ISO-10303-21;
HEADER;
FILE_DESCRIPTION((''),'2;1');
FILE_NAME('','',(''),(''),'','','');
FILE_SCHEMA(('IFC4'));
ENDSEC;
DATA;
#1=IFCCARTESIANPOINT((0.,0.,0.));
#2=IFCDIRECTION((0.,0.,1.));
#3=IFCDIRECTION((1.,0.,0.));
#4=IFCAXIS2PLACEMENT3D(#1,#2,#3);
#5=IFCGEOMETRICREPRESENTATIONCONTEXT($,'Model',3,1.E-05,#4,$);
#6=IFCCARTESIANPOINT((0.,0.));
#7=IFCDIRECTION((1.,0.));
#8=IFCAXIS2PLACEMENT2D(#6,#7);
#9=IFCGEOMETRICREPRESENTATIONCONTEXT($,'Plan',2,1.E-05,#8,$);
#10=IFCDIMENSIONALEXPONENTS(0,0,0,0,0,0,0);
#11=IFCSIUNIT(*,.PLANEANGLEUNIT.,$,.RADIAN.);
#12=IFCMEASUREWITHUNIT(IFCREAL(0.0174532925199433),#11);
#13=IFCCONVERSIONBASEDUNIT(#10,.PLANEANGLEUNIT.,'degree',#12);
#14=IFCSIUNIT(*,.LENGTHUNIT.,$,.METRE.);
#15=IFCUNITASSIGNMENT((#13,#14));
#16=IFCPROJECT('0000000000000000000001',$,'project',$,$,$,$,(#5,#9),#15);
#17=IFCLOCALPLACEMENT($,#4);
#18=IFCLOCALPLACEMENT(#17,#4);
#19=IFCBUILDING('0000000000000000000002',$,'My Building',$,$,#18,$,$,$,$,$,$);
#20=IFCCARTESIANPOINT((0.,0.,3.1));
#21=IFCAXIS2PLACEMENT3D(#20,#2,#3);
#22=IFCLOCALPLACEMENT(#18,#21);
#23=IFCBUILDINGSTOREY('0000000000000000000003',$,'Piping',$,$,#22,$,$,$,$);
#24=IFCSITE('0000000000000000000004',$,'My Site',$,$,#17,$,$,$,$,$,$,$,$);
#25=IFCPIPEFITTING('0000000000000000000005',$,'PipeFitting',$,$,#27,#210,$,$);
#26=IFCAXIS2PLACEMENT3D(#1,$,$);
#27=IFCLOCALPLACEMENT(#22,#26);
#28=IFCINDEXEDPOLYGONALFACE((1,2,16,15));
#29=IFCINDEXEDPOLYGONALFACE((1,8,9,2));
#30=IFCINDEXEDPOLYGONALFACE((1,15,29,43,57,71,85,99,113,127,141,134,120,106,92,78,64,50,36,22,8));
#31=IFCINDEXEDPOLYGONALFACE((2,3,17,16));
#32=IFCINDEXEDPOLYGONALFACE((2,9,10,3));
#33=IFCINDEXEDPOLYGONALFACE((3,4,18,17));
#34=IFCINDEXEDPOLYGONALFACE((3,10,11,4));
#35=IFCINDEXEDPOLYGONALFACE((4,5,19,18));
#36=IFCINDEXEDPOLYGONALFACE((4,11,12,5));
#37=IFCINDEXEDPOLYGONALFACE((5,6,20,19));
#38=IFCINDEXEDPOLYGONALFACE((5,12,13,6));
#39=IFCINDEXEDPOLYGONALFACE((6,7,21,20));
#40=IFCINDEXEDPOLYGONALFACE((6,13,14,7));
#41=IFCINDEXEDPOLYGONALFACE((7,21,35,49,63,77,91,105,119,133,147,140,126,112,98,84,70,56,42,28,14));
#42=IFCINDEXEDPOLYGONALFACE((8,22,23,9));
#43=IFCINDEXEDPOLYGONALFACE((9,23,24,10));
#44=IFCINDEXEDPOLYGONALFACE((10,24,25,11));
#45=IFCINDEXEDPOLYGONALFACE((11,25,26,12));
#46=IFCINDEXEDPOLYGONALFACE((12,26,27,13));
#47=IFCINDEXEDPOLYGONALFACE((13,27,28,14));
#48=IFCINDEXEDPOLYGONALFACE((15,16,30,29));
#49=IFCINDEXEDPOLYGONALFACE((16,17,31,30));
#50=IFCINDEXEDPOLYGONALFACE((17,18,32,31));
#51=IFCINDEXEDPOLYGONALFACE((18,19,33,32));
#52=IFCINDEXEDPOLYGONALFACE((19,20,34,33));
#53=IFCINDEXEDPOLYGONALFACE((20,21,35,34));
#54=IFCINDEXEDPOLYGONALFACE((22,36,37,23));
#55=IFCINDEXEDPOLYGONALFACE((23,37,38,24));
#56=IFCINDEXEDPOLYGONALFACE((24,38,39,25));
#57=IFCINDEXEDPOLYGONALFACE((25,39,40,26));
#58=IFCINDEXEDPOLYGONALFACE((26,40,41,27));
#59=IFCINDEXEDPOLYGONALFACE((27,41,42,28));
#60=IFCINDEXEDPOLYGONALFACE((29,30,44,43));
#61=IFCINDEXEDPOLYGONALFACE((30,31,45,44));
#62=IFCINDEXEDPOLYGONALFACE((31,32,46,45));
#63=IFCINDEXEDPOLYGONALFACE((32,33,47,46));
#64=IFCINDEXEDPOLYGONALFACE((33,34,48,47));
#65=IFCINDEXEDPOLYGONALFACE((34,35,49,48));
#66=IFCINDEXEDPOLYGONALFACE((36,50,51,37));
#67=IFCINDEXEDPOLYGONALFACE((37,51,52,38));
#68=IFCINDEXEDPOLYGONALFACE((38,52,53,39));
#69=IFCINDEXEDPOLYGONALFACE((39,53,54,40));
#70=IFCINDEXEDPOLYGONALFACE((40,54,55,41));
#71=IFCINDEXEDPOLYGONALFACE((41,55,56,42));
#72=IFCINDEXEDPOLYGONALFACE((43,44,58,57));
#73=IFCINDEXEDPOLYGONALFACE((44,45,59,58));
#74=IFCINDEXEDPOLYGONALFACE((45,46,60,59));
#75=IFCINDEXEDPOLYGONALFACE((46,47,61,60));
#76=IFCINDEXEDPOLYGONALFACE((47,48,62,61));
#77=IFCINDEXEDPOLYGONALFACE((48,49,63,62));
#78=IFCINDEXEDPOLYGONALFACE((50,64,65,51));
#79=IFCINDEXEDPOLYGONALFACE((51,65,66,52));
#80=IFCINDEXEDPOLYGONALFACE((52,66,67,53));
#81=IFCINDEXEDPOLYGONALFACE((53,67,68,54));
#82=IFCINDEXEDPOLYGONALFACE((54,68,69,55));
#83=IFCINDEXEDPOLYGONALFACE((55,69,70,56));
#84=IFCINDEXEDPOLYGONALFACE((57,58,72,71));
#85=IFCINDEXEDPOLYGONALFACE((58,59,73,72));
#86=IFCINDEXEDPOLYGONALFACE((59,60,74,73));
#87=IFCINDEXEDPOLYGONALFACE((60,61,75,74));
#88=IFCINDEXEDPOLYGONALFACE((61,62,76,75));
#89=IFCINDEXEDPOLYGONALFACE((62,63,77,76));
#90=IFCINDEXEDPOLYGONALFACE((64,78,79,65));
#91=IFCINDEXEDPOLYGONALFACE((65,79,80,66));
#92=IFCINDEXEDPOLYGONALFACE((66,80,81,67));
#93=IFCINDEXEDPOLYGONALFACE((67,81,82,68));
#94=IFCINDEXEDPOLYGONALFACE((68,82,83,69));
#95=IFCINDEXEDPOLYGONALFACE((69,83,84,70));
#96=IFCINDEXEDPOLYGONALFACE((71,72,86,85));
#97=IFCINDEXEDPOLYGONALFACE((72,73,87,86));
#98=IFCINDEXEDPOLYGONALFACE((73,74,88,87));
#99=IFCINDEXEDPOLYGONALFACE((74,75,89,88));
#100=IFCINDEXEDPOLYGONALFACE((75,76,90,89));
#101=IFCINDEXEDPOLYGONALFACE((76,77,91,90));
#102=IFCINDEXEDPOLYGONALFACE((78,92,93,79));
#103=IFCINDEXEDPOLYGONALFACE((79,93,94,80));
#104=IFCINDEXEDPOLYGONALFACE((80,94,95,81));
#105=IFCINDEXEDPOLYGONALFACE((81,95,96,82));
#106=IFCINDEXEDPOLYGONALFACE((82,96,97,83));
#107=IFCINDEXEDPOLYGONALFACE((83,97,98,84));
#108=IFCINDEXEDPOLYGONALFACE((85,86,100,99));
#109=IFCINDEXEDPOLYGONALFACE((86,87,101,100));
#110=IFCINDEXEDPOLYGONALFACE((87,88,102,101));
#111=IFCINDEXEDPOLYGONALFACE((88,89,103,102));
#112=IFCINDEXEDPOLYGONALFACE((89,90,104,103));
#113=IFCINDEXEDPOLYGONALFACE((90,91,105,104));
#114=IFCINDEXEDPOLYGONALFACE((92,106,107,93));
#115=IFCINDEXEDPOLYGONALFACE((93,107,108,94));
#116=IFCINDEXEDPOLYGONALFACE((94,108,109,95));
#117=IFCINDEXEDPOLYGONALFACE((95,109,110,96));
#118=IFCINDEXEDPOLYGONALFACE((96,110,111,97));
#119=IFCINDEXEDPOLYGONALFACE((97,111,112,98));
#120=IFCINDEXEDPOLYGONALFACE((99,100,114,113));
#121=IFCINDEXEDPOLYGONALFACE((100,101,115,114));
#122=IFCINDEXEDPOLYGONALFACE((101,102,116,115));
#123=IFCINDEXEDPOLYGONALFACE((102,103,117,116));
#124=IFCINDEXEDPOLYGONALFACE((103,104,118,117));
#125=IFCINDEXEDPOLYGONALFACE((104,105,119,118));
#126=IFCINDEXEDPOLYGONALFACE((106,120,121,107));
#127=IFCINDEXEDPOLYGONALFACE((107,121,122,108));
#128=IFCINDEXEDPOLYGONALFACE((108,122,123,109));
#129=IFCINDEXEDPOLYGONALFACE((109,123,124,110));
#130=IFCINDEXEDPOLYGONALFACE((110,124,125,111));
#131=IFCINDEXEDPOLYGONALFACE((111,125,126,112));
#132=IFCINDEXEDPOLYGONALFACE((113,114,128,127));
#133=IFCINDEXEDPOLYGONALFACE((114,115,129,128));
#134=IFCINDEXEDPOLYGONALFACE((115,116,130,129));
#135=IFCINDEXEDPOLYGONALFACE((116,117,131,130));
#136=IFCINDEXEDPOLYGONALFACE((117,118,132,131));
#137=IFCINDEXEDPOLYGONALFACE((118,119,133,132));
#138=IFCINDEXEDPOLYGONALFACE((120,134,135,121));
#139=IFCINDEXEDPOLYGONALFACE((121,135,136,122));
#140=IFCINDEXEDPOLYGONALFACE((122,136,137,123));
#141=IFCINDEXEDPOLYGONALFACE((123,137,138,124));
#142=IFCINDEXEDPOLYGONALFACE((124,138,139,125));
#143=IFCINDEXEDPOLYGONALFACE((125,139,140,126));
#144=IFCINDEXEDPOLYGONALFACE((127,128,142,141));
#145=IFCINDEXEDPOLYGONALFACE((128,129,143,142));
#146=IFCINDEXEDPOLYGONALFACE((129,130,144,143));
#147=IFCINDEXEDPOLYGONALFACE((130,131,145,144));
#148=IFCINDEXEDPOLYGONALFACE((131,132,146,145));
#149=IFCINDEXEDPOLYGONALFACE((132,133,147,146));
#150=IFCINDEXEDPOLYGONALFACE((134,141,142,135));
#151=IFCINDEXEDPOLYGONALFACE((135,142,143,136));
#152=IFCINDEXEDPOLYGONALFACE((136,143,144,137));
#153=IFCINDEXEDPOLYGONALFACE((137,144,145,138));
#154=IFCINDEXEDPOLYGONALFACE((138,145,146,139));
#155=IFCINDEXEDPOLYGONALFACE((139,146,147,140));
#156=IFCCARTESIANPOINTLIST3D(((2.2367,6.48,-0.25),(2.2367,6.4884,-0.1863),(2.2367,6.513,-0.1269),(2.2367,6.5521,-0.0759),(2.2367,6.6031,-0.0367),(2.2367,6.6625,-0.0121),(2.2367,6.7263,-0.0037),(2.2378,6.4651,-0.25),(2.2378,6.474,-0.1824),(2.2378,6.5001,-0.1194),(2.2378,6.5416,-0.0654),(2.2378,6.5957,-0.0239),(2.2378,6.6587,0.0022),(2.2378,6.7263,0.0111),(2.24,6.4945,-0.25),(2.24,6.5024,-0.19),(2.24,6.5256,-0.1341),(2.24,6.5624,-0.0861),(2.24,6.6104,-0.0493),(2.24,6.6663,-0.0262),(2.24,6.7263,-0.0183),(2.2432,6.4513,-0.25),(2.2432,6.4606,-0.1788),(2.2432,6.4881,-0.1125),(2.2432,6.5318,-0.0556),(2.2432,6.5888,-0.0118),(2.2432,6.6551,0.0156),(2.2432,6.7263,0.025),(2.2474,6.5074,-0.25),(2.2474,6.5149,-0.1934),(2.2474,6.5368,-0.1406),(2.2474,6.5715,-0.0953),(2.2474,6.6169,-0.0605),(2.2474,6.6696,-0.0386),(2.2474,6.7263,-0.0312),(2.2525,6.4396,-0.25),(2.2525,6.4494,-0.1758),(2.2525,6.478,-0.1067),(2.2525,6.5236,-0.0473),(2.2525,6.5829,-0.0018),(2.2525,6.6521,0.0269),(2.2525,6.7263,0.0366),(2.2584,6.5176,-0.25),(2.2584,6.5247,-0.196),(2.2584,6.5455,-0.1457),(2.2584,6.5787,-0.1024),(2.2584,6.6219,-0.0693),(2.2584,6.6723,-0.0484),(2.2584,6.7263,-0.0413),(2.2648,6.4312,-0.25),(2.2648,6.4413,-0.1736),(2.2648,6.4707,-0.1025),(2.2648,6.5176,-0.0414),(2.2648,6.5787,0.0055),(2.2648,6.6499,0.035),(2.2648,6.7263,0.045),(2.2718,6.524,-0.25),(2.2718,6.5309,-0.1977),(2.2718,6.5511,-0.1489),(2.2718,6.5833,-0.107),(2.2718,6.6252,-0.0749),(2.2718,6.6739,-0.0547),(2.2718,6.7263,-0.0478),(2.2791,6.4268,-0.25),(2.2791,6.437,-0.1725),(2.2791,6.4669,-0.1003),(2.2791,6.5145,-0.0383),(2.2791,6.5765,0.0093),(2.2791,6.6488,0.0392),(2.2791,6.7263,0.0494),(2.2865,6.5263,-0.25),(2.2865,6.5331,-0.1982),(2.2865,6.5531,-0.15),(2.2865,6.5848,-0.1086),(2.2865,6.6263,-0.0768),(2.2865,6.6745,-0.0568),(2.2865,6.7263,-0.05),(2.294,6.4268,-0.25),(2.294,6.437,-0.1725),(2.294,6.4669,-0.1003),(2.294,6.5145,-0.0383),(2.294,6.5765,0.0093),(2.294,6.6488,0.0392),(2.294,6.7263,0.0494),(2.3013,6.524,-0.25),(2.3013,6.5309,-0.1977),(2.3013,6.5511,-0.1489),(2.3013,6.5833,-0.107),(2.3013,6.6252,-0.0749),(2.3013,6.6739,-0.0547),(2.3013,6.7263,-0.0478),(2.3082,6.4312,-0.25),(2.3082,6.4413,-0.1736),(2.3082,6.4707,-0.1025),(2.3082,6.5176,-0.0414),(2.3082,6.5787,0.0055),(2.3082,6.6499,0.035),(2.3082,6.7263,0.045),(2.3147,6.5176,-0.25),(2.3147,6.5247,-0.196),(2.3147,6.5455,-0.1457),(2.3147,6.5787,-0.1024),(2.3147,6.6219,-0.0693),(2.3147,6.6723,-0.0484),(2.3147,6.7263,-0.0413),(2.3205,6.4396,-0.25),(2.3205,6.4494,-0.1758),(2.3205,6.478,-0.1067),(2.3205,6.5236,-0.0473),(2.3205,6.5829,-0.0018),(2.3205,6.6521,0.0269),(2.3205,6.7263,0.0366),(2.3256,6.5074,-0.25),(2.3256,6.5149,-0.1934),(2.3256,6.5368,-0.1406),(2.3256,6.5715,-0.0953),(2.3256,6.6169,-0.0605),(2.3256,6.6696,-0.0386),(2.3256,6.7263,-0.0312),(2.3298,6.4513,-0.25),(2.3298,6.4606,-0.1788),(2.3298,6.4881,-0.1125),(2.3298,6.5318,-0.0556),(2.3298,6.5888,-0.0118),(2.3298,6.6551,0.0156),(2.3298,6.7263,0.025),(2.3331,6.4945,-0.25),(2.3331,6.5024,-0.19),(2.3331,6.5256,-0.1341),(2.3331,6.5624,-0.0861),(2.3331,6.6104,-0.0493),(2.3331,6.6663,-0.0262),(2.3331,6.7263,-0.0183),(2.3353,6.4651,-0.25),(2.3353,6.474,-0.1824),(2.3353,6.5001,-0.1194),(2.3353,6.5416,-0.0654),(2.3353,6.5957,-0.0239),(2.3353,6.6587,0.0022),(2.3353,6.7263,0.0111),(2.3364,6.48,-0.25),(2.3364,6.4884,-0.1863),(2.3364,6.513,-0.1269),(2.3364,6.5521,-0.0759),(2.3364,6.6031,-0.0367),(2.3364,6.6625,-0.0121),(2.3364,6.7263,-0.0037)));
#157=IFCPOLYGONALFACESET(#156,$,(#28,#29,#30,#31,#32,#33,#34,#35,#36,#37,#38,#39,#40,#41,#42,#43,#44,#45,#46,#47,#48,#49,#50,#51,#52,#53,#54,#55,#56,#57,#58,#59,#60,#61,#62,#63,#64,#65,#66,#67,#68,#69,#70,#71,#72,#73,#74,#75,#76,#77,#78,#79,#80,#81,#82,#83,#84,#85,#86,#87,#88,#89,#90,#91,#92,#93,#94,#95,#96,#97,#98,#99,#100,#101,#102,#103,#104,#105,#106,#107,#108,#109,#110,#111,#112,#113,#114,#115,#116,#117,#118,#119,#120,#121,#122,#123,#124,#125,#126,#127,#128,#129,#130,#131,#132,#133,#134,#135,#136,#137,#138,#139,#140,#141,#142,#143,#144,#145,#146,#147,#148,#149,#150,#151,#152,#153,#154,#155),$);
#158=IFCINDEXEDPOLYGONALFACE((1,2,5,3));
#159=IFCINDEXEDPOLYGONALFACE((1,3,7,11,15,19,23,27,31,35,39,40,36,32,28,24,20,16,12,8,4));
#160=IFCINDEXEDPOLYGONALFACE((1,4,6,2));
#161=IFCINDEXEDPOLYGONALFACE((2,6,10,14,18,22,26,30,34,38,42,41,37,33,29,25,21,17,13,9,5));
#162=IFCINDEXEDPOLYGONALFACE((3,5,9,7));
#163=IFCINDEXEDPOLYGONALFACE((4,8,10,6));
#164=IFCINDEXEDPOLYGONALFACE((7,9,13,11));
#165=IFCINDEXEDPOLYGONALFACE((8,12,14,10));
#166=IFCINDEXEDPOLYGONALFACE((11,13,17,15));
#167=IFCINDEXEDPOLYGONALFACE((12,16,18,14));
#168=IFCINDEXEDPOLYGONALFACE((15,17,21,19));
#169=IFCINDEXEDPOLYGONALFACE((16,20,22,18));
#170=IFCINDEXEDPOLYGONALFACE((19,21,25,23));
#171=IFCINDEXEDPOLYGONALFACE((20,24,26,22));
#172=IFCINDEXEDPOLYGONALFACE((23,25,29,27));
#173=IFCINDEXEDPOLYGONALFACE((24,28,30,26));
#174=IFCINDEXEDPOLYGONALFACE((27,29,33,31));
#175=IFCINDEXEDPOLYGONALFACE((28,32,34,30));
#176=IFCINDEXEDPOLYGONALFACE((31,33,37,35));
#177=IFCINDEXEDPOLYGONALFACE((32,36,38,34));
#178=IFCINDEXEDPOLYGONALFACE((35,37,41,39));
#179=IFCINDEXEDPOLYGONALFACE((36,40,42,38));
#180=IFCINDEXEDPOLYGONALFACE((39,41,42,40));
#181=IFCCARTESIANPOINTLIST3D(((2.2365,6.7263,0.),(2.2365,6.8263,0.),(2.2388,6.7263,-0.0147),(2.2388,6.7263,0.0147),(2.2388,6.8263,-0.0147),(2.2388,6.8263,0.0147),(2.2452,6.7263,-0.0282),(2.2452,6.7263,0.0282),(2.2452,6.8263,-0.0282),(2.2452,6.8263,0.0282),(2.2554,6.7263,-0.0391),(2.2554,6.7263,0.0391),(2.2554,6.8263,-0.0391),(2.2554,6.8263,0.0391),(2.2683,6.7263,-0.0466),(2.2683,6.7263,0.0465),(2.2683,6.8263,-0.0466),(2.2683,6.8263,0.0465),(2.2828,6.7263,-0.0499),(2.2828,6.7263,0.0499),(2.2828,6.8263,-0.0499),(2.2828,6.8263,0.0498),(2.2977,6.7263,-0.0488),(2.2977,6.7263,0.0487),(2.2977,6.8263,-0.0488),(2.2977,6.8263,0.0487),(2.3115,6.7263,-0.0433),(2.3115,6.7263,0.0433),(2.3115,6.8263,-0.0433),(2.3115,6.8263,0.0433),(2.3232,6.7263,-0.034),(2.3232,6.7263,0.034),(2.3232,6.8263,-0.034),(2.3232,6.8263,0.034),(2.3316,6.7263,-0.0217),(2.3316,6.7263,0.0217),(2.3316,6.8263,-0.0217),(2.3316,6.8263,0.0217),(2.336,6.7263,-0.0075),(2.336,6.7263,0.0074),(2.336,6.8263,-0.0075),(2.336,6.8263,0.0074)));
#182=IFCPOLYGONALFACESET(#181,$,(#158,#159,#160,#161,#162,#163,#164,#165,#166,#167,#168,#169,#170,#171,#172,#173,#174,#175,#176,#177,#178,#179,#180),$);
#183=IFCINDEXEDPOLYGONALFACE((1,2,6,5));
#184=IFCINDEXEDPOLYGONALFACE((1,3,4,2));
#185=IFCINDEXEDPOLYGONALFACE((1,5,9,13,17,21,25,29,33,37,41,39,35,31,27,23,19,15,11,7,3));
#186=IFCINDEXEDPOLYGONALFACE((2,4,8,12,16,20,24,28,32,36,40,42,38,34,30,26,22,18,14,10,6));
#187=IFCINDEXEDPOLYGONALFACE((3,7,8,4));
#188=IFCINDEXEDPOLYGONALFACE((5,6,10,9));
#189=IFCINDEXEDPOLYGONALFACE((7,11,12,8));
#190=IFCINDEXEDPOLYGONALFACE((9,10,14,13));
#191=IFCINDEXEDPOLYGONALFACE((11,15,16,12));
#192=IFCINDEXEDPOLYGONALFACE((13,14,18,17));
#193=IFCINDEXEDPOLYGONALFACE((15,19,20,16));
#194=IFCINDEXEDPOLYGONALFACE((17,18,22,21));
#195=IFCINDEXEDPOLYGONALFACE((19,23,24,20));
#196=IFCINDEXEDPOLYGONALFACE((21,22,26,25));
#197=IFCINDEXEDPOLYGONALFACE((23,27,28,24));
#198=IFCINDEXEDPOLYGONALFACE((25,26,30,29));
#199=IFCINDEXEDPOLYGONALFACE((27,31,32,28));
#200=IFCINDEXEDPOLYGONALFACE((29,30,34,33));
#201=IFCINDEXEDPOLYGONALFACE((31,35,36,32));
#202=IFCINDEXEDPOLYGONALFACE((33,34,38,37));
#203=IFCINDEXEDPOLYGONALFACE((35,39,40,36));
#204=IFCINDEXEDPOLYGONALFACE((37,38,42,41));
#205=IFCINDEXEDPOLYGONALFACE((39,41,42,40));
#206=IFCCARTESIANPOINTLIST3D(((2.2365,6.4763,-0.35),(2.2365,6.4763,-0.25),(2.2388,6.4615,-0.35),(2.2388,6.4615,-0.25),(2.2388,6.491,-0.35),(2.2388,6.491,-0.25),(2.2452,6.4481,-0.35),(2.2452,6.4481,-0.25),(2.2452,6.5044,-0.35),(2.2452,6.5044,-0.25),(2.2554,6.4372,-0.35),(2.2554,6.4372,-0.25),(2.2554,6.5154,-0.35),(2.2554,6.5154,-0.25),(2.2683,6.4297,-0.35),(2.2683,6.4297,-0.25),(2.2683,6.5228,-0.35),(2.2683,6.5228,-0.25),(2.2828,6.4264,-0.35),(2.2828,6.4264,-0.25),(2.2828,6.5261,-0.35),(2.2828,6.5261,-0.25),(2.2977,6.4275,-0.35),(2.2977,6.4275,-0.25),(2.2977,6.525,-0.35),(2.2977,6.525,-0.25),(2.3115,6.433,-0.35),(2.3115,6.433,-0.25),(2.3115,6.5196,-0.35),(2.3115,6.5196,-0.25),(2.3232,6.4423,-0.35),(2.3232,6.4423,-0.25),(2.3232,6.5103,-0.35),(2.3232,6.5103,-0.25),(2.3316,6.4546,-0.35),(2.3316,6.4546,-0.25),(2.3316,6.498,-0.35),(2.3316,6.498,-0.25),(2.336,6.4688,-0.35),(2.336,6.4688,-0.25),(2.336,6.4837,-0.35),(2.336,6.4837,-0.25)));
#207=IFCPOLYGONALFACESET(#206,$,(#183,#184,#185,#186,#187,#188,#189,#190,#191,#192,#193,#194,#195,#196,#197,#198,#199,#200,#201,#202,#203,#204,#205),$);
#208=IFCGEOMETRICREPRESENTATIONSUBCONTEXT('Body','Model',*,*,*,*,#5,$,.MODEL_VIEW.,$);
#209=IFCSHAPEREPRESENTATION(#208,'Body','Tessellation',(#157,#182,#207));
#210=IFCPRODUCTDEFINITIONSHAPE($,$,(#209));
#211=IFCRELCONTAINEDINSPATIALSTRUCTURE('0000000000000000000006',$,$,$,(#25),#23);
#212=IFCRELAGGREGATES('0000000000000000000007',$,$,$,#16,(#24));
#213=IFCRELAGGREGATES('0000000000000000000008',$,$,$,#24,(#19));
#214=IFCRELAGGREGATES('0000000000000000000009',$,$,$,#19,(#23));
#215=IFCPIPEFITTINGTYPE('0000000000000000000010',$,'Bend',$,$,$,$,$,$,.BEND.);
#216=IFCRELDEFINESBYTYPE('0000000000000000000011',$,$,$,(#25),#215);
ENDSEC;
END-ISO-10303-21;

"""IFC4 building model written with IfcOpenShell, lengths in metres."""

from ifc_helpers import new_model, entity, si_unit, converted_unit, frame, origin_with_axes, origin_2d_with_axis, place, context, subcontext, project, spatial, circle, extrude, source, transform, mapped, type_object, type_shapes, element, save


model = new_model("IFC4")

# Units and contexts
model_context = context("Model", 3, precision=1e-05, world=origin_with_axes())
plan_context = context("Plan", 2, precision=1e-05, world=origin_2d_with_axis())
body_context = subcontext(model_context, "Body", "Model", "MODEL_VIEW")
ifc_project = project(units=[converted_unit("PLANEANGLEUNIT", "degree", entity("IfcReal", 0.0174532925199433), si_unit("PLANEANGLEUNIT", "RADIAN"), dimensions=[0, 0, 0, 0, 0, 0, 0]), si_unit("LENGTHUNIT", "METRE")], contexts=[model_context, plan_context])

# Site, building, storey
site_placement = place(None, origin_with_axes())
site = spatial("IfcSite", under=ifc_project, at=site_placement, Name="My Site")
building_placement = place(site_placement, origin_with_axes())
building = spatial("IfcBuilding", under=site, at=building_placement, Name="My Building")
storey_placement = place(building_placement, frame((0.0, 0.0, 3.1), z_axis=(0.0, 0.0, 1.0), x_axis=(1.0, 0.0, 0.0)))
storey = spatial("IfcBuildingStorey", under=building, at=storey_placement, Name="Piping")

# Pipe fitting
pipe_fitting_type_1 = type_object("IfcPipeFittingType", Name="Bend", PredefinedType="BEND")
shared_shape_1 = source(origin_with_axes(), body_context, "Body", "SolidModel", [
    entity("IfcSweptDiskSolid", entity("IfcIndexedPolyCurve", entity("IfcCartesianPointList3D", [[0.0, 0.0, -0.1], [0.0, -0.0732, -0.2768], [0.0, -0.25, -0.35]]), [entity("IfcArcIndex", [1, 2, 3])]), 0.05),
    extrude(circle(Radius=0.05), origin_with_axes(), (0.0, 0.0, -1.0), 0.1),
    extrude(circle(Radius=0.05), frame((0.0, -0.25, -0.35), z_axis=(0.0, -1.0, 0.000022), x_axis=(1.0, 0.0, 0.0)), (0.0, 0.0, 1.0), 0.1),
])
type_shapes(pipe_fitting_type_1, [shared_shape_1])
for number, where, z_axis, x_axis, name in (
    (1, (2.2865, 6.8263, 0.0), (0.0, 1.0, -0.000022), (-1.0, 0.0, 0.0), "PipeFitting"),
):
    element("IfcPipeFitting", number, at=place(storey_placement, frame(where, z_axis=z_axis, x_axis=x_axis)), inside=storey, type_object=pipe_fitting_type_1, Name=name, context=body_context, shape_type="MappedRepresentation", body=[
        mapped(shared_shape_1, transform((0.0, 0.0, 0.0), x_axis=(1.0, 0.0, 0.0), y_axis=(0.0, 1.0, 0.0), z_axis=(0.0, 0.0, 1.0), scale=1.0)),
    ])

save(model, "model.ifc")
